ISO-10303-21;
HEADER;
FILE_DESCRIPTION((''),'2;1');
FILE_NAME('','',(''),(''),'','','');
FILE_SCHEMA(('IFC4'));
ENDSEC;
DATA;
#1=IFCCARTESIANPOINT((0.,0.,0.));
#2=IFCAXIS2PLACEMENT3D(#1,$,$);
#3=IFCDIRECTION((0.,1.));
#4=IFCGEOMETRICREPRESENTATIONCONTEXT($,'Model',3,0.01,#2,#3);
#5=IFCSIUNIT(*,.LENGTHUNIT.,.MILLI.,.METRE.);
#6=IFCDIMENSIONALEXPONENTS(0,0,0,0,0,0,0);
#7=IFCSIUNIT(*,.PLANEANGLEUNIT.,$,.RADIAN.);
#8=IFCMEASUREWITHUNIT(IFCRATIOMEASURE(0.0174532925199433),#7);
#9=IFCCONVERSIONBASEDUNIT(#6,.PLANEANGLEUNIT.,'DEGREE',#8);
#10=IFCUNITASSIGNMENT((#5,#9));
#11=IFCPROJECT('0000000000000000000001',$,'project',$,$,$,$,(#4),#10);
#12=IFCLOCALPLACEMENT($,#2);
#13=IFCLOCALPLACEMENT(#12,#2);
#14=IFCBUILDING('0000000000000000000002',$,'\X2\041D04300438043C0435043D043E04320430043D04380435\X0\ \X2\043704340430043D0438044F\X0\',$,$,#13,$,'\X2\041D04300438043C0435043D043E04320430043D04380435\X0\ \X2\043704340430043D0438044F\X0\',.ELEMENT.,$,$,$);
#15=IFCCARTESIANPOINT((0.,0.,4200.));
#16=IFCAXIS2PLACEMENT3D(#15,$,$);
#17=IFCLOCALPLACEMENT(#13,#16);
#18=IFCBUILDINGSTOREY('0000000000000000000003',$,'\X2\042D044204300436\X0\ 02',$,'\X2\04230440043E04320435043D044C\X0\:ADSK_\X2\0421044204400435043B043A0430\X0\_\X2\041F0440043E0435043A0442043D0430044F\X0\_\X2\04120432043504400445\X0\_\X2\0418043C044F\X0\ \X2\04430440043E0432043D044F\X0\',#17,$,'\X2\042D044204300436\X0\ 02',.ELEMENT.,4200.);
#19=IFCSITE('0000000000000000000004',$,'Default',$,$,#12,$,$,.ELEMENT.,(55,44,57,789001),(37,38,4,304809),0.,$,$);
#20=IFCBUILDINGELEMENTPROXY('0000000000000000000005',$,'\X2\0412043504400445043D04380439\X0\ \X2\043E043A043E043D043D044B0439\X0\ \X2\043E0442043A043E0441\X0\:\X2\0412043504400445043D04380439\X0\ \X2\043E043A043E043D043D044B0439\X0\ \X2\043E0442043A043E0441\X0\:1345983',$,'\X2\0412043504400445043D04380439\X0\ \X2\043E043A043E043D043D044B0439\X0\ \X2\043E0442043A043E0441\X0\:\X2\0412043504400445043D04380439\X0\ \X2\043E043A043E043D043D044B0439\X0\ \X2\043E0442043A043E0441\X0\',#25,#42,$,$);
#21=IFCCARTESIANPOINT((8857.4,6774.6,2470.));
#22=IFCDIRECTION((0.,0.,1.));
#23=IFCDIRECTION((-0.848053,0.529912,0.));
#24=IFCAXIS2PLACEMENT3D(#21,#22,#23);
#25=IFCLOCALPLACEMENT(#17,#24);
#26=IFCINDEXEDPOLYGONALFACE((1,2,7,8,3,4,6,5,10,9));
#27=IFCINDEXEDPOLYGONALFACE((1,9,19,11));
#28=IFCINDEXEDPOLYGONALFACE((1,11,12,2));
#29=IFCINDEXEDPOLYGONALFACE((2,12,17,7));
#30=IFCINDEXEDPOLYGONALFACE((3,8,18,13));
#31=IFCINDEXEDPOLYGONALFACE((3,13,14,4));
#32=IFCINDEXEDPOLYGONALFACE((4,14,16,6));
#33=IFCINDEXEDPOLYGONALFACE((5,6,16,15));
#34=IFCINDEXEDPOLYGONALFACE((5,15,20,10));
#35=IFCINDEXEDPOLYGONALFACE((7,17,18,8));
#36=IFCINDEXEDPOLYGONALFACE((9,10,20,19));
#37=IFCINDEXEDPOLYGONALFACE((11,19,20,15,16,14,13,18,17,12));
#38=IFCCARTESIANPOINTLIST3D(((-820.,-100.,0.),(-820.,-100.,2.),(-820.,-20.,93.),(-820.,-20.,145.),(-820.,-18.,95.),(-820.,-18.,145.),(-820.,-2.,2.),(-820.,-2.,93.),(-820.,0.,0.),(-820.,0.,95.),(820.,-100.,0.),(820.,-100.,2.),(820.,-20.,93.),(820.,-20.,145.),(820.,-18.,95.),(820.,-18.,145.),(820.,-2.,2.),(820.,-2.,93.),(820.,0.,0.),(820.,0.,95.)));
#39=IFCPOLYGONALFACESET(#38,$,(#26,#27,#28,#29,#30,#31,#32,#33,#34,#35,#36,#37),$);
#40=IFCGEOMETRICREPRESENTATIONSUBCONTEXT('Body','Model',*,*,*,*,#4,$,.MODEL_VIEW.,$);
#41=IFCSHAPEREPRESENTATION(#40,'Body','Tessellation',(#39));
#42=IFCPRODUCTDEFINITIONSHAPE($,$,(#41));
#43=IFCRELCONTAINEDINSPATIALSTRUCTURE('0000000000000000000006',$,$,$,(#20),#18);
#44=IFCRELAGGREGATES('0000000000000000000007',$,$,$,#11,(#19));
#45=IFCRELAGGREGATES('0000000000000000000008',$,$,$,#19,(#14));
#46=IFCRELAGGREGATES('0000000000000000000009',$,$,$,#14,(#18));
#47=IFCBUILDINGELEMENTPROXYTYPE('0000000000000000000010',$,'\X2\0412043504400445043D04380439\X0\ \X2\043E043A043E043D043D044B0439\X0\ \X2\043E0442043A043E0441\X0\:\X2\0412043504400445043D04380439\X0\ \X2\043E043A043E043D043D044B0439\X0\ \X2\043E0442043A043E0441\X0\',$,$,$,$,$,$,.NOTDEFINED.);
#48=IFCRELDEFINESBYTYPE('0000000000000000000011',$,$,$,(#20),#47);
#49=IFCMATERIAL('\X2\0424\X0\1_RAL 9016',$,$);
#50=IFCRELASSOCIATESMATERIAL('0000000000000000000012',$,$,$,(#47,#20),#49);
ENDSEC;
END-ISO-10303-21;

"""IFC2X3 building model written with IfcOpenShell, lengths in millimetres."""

from ifc_helpers import new_model, entity, si_unit, converted_unit, direction, frame, origin, place, context, subcontext, project, spatial, polyline, outline, extrude, source, transform, mapped, material, type_object, type_shapes, element, save


model = new_model("IFC2X3")

# Units and contexts
model_context = context("Model", 3, precision=0.01, world=origin(), true_north=direction((0.0, 1.0)))
body_context = subcontext(model_context, "Body", "Model", "MODEL_VIEW")
ifc_project = project(units=[si_unit("LENGTHUNIT", "METRE", prefix="MILLI"), converted_unit("PLANEANGLEUNIT", "DEGREE", entity("IfcRatioMeasure", 0.0174532925199433), si_unit("PLANEANGLEUNIT", "RADIAN"), dimensions=[0, 0, 0, 0, 0, 0, 0])], contexts=[model_context])

# Site, building, storey
site_placement = place(None, origin())
site = spatial("IfcSite", under=ifc_project, at=site_placement, Name="Default", CompositionType="ELEMENT", RefLatitude=(55, 44, 57, 789001), RefLongitude=(37, 38, 4, 304809), RefElevation=0.0)
building_placement = place(site_placement, origin())
building = spatial("IfcBuilding", under=site, at=building_placement, Name="Наименование здания", LongName="Наименование здания", CompositionType="ELEMENT")
storey_placement = place(building_placement, frame((0.0, 0.0, 4200.0)))
storey = spatial("IfcBuildingStorey", under=building, at=storey_placement, Name="Этаж 02", ObjectType="Уровень:ADSK_Стрелка_Проектная_Вверх_Имя уровня", LongName="Этаж 02", CompositionType="ELEMENT", Elevation=4200.0)

# Building element proxy
ifc_material_1 = material(Name="Ф1_RAL 9016")
building_element_proxy_type_1 = type_object("IfcBuildingElementProxyType", Name="Верхний оконный откос:Верхний оконный откос", PredefinedType="NOTDEFINED", material=ifc_material_1)
shared_shape_1 = source(origin(), body_context, "Body", "SweptSolid", [
    extrude(outline(polyline([(28.0, -10.0), (78.0, -10.0), (78.0, -8.0), (26.0, -8.0), (26.0, -26.0), (-65.0, -26.0), (-65.0, 72.0), (-67.0, 72.0), (-67.0, -28.0), (28.0, -28.0), (28.0, -10.0)])), frame((-820.0, -28.0, 67.0), z_axis=(1.0, 0.0, 0.0), x_axis=(0.0, 0.0, 1.0)), (0.0, 0.0, 1.0), 1640.0),
])
type_shapes(building_element_proxy_type_1, [shared_shape_1])
proxy_1_placement = place(storey_placement, frame((8857.4, 6774.6, 2470.0), z_axis=(0.0, 0.0, 1.0), x_axis=(-0.848053, 0.529912, 0.0)))
element("IfcBuildingElementProxy", 1, at=proxy_1_placement, inside=storey, type_object=building_element_proxy_type_1, material=ifc_material_1, Name="Верхний оконный откос:Верхний оконный откос:1345983", ObjectType="Верхний оконный откос:Верхний оконный откос", context=body_context, shape_type="MappedRepresentation", body=[
    mapped(shared_shape_1, transform((0.0, 0.0, 0.0), scale=1.0)),
])

save(model, "model.ifc")
